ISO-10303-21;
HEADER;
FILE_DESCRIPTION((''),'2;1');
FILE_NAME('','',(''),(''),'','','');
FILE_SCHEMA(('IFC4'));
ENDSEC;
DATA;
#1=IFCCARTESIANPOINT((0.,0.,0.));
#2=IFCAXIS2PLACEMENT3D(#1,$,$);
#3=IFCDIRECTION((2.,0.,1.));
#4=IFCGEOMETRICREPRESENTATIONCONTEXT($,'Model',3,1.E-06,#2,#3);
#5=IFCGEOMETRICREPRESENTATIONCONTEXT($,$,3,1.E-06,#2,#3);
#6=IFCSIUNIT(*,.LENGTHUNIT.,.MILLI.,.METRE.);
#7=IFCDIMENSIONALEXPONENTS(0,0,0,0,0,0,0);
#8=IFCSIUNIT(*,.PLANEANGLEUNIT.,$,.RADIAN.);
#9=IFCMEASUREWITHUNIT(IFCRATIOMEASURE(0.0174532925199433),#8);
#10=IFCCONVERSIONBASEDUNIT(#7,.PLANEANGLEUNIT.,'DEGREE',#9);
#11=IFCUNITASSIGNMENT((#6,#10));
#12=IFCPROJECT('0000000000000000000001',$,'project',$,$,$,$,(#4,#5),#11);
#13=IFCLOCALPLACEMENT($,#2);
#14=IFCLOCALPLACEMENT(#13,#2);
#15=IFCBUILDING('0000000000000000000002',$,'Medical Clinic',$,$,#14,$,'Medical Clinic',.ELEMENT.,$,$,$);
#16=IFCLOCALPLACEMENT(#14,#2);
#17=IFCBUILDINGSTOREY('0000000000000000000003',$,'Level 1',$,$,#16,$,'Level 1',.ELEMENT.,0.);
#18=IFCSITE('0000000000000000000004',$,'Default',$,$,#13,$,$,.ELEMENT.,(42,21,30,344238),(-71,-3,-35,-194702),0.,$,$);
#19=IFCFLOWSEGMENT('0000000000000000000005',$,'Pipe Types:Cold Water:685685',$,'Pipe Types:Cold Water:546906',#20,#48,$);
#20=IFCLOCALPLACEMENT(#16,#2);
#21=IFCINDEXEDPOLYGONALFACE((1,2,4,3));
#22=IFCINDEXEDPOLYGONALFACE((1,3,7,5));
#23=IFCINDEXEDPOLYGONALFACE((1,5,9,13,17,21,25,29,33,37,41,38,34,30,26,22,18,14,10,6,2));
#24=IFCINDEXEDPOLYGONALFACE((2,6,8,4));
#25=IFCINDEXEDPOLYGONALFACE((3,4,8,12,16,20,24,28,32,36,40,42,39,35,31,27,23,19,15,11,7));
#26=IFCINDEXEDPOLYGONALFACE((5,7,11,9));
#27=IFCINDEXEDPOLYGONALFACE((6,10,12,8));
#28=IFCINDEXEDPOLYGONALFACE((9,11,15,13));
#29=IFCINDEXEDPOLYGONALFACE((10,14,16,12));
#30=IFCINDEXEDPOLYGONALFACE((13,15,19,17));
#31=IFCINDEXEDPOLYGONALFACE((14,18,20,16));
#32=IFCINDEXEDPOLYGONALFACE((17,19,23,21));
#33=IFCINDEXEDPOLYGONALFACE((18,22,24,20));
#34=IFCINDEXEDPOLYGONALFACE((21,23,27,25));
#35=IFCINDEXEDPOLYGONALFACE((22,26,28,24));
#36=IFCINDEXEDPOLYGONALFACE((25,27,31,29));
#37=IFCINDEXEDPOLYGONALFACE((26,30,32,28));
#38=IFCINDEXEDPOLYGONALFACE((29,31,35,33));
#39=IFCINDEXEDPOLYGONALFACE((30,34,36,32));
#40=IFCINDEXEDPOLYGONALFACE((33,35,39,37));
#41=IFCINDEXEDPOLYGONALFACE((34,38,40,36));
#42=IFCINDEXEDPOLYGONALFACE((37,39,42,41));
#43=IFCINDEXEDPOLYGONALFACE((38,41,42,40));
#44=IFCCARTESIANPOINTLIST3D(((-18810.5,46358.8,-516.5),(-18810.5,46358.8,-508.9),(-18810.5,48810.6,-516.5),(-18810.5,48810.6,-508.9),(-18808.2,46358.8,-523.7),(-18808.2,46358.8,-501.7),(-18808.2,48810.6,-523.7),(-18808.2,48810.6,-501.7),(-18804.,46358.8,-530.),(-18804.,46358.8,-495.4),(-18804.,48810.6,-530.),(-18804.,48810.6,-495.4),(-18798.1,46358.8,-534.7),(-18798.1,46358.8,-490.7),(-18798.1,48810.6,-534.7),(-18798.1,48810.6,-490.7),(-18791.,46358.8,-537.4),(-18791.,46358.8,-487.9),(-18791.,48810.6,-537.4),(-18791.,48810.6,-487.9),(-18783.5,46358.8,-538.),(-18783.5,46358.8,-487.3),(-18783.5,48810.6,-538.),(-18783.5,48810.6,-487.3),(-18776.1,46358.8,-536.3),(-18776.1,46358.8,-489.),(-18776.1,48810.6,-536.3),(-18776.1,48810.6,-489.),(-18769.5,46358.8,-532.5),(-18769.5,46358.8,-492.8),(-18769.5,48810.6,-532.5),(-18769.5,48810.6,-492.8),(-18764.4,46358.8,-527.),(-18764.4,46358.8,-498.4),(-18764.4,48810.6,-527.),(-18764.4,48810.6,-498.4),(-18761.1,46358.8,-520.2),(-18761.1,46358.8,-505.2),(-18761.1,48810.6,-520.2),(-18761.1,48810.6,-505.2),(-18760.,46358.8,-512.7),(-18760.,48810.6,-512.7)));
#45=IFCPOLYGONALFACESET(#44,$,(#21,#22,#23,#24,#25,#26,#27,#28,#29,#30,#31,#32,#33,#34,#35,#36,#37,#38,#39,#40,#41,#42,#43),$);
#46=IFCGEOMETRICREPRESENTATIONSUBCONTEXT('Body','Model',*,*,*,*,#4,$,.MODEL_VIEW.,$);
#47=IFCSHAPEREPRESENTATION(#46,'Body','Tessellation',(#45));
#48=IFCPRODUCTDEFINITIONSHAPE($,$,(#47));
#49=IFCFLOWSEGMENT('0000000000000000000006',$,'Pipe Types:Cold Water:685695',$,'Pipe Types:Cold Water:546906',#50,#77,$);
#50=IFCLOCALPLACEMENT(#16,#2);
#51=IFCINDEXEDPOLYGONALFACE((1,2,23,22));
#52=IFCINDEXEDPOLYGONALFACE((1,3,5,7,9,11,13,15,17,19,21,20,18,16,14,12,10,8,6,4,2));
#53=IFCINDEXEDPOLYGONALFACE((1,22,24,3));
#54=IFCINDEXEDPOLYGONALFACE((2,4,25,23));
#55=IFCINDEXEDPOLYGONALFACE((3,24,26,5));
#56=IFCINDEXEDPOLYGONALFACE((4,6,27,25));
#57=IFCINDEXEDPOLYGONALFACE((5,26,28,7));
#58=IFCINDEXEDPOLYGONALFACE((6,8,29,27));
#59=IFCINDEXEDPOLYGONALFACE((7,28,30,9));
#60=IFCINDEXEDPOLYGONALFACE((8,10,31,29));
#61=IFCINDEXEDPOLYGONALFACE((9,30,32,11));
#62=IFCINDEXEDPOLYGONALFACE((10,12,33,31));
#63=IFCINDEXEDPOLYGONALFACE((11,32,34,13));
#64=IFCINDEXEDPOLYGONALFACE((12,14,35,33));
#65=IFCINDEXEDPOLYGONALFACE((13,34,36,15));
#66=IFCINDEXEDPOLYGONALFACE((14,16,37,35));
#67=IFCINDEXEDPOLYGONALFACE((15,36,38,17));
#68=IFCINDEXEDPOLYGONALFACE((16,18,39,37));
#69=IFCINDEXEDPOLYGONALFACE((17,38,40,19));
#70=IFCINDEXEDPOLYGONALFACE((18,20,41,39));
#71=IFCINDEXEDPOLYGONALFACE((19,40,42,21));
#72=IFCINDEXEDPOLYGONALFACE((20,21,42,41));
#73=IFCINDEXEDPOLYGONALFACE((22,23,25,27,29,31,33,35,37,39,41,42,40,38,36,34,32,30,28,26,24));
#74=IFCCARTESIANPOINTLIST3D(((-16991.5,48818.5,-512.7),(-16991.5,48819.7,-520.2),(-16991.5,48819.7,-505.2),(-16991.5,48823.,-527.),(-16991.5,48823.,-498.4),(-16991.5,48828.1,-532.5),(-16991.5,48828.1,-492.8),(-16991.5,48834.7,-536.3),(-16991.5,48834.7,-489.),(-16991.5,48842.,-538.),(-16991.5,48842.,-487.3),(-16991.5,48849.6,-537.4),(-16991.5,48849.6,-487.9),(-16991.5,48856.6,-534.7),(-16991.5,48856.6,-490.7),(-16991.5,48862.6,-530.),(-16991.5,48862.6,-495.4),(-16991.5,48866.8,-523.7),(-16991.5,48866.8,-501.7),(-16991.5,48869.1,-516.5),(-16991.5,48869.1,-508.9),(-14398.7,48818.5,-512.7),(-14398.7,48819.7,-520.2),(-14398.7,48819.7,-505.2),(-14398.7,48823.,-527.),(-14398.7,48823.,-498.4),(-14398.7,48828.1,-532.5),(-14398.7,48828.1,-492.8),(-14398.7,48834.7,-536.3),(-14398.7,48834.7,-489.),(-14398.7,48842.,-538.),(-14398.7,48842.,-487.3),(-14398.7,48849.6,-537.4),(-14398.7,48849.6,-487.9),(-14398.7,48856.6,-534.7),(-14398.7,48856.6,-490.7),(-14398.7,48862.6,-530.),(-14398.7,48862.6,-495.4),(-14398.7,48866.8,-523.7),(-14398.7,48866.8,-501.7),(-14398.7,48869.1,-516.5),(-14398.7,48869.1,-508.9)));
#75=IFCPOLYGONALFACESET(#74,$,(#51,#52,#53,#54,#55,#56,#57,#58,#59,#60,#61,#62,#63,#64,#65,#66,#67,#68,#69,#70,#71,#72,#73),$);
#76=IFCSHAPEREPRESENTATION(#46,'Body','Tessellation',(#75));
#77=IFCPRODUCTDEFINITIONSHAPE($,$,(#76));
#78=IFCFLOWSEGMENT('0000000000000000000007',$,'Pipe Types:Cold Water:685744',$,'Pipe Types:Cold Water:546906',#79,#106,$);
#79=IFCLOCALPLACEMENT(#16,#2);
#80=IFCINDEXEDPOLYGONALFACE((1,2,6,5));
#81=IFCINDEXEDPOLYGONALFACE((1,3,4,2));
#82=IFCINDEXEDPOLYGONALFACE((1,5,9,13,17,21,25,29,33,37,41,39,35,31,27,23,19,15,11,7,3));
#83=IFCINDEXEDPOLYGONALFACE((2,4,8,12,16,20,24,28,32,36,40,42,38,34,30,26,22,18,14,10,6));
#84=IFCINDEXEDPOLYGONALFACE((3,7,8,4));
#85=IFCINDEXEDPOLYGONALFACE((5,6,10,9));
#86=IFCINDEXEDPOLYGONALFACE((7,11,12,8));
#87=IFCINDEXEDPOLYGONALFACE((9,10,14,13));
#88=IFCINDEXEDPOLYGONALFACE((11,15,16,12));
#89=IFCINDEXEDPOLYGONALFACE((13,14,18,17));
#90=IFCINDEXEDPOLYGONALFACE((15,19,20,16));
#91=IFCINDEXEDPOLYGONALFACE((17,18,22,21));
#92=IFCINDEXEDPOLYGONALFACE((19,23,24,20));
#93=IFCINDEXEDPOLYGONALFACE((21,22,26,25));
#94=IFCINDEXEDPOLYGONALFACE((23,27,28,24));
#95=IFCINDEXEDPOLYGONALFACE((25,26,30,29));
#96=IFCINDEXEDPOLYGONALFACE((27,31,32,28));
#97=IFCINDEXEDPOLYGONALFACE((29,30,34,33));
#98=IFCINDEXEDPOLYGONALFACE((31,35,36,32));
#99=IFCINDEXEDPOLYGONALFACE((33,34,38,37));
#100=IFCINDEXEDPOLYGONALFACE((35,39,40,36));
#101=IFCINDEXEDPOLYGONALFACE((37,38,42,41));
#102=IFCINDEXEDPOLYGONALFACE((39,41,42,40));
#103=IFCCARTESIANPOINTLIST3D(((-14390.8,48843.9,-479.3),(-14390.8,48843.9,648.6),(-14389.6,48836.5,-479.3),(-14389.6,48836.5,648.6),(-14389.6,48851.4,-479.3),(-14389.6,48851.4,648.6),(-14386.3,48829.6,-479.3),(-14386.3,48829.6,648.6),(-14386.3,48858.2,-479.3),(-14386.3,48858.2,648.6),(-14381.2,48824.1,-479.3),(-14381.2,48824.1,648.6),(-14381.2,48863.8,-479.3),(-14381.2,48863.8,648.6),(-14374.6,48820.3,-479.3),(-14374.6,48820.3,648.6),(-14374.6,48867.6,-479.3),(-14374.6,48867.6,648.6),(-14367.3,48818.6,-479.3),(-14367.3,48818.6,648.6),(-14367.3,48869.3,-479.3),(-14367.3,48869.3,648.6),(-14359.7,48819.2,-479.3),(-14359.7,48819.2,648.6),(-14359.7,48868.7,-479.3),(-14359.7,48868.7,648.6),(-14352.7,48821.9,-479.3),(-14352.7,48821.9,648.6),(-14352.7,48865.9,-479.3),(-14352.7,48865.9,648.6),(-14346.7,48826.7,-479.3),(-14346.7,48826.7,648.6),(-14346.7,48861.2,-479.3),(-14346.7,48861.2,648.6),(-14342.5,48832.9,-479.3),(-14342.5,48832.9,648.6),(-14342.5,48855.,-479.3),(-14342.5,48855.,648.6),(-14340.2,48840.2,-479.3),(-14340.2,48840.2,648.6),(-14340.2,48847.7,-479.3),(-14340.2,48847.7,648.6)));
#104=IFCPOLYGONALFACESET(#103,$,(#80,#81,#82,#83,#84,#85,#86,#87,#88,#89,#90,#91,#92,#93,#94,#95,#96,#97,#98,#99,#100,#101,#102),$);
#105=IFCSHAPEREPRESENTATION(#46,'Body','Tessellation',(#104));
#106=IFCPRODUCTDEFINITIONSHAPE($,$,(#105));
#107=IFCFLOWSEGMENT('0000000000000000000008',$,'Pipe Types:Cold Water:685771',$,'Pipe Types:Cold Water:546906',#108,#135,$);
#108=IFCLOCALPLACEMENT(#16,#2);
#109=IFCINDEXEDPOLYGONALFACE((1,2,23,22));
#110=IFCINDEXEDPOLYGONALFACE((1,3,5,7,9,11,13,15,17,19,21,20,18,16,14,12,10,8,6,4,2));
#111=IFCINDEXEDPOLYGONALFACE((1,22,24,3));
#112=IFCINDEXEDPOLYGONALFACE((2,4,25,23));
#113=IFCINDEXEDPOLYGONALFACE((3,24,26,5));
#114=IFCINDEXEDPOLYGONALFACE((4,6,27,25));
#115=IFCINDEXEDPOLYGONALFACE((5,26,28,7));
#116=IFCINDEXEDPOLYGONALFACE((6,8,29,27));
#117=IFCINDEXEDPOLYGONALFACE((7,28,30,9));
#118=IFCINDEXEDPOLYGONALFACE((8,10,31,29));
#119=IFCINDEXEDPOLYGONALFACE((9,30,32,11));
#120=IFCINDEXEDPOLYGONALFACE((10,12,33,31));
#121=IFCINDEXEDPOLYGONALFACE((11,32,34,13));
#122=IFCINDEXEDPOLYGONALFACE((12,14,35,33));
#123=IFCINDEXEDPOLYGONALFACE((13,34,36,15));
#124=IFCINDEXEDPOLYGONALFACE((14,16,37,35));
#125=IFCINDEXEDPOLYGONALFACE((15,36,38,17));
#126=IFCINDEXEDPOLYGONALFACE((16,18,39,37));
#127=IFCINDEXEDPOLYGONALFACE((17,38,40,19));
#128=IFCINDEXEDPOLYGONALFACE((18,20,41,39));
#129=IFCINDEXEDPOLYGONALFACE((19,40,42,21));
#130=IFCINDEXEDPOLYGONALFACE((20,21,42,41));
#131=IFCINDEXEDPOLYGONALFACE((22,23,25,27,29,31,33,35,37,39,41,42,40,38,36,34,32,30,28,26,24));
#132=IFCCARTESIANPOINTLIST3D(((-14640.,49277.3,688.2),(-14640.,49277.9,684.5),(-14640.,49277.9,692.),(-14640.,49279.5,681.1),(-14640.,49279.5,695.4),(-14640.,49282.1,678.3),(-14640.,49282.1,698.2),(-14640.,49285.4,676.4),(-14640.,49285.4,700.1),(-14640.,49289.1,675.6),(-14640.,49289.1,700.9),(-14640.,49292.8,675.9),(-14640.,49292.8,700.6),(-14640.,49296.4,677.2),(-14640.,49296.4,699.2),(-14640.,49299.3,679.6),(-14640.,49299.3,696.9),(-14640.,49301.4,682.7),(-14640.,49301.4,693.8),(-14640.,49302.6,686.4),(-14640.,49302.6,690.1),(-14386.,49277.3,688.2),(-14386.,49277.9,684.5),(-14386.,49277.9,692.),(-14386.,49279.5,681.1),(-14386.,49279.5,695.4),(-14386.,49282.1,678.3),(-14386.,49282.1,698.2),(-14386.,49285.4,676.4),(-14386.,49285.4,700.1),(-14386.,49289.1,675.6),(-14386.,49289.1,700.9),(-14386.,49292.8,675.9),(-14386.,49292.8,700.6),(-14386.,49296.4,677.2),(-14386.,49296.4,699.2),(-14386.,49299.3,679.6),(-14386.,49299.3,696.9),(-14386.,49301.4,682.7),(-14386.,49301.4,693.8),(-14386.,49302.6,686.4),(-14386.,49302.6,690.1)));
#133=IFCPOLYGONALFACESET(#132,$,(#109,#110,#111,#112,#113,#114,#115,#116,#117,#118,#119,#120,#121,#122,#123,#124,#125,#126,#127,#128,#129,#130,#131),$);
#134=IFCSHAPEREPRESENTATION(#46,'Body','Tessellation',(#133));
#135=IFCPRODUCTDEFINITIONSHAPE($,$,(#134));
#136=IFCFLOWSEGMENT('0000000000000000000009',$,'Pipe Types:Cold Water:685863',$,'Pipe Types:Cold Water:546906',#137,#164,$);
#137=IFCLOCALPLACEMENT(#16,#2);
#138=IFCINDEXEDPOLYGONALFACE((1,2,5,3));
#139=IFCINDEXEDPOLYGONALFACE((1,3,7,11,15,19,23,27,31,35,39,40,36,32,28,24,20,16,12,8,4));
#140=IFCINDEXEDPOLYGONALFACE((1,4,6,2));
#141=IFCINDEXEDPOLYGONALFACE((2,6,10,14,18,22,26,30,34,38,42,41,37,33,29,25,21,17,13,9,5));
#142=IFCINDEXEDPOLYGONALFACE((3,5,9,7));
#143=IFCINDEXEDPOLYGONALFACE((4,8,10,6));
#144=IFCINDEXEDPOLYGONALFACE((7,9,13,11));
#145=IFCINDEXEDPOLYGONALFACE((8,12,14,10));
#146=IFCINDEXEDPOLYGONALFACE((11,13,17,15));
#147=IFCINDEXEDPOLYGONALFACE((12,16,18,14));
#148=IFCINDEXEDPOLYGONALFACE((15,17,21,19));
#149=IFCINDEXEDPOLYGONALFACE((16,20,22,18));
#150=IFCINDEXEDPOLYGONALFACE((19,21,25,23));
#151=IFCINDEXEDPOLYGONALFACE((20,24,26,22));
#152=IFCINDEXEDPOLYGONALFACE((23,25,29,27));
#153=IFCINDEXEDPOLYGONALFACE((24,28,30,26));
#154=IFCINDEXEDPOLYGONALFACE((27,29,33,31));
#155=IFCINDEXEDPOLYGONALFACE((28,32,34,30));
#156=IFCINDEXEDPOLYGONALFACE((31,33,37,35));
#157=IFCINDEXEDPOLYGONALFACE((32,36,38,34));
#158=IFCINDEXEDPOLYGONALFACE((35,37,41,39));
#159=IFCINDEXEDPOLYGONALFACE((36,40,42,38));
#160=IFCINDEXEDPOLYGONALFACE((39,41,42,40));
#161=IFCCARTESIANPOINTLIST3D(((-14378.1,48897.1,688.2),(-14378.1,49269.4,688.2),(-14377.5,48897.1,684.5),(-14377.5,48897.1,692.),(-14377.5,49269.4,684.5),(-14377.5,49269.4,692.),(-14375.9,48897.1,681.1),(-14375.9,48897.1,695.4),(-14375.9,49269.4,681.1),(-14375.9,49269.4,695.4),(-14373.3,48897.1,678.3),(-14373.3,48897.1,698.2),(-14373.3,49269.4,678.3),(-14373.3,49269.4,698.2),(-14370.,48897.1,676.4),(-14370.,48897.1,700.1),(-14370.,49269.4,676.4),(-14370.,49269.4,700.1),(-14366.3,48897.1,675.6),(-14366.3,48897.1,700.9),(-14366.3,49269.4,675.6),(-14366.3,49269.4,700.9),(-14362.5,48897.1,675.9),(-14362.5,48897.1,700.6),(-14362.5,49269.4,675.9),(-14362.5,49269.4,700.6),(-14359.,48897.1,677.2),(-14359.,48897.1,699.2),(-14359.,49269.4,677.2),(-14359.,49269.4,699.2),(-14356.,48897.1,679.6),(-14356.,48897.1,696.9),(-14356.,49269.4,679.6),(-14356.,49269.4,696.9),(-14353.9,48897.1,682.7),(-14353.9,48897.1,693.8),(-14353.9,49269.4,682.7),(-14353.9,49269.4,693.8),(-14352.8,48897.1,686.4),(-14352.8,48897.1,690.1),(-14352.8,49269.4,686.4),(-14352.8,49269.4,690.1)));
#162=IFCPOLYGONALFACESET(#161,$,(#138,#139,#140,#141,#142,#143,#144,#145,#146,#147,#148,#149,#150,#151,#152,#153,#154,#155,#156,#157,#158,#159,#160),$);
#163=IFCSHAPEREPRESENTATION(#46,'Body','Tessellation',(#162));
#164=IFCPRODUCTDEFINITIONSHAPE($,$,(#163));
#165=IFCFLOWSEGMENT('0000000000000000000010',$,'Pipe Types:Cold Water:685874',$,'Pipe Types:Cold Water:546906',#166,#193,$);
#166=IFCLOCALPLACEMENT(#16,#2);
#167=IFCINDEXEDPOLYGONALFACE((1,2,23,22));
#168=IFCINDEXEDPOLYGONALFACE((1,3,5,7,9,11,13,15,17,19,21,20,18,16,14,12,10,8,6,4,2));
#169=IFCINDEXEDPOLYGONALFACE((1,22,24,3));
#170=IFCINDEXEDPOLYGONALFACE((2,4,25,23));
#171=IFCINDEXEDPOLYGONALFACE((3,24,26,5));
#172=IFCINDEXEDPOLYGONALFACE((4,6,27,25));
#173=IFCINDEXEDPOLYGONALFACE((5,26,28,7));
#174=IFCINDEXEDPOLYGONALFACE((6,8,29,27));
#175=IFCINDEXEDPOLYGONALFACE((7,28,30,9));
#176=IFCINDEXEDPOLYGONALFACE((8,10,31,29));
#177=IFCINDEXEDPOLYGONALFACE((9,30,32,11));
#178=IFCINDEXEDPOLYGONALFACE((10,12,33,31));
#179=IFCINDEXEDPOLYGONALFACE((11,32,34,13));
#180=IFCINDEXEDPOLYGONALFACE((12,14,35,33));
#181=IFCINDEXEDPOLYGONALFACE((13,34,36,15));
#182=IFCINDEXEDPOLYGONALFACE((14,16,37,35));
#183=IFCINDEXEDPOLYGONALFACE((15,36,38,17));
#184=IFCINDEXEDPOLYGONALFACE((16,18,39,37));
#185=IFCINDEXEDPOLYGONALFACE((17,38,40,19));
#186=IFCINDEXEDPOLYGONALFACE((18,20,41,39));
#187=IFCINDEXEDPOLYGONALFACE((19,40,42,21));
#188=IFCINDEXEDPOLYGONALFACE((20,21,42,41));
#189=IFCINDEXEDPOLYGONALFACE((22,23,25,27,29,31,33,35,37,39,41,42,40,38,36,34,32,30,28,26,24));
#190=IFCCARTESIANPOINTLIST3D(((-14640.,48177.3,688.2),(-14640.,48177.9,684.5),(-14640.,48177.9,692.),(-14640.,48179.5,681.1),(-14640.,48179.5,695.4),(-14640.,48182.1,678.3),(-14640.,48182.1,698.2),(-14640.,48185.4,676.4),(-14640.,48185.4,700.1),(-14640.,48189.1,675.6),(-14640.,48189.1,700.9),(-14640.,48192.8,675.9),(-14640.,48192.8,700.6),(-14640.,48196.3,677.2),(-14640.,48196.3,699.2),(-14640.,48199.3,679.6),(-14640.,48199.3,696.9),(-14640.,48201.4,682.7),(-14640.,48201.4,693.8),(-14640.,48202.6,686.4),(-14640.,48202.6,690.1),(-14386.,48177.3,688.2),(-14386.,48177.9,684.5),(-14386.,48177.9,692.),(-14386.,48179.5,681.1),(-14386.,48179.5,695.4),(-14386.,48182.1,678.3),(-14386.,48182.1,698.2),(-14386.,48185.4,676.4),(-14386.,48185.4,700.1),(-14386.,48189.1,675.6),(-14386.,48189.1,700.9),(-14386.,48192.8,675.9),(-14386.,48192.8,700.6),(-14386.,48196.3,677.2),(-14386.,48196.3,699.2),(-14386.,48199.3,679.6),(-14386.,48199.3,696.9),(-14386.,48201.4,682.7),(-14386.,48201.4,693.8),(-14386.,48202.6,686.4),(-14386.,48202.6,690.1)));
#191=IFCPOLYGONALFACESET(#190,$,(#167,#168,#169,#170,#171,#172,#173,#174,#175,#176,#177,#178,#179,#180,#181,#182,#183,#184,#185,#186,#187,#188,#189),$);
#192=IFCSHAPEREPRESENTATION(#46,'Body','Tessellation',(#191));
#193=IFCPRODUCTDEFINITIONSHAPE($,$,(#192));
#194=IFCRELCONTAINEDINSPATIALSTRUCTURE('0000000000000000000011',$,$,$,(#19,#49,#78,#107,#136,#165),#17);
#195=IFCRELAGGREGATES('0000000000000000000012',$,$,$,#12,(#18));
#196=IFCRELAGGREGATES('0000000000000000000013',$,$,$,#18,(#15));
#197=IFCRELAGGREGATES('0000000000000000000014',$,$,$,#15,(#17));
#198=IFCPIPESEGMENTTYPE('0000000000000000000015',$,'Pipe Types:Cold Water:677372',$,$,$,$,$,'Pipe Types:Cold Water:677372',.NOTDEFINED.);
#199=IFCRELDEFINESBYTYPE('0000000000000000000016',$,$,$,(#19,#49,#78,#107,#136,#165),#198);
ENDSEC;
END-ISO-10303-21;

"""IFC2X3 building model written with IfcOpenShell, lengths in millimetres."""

from ifc_helpers import new_model, entity, si_unit, converted_unit, direction, frame, frame_2d, origin, place, context, subcontext, project, spatial, circle, extrude, type_object, element, save


model = new_model("IFC2X3")

# Units and contexts
model_context = context("Model", 3, precision=1e-06, world=origin(), true_north=direction((2.0, 0.0, 1.0)))
context_of_model = context(None, 3, precision=1e-06, world=origin(), true_north=direction((2.0, 0.0, 1.0)))
body_context = subcontext(model_context, "Body", "Model", "MODEL_VIEW")
ifc_project = project(units=[si_unit("LENGTHUNIT", "METRE", prefix="MILLI"), converted_unit("PLANEANGLEUNIT", "DEGREE", entity("IfcRatioMeasure", 0.0174532925199433), si_unit("PLANEANGLEUNIT", "RADIAN"), dimensions=[0, 0, 0, 0, 0, 0, 0])], contexts=[model_context, context_of_model])

# Site, building, storey
site_placement = place(None, origin())
site = spatial("IfcSite", under=ifc_project, at=site_placement, Name="Default", CompositionType="ELEMENT", RefLatitude=(42, 21, 30, 344238), RefLongitude=(-71, -3, -35, -194702), RefElevation=0.0)
building_placement = place(site_placement, origin())
building = spatial("IfcBuilding", under=site, at=building_placement, Name="Medical Clinic", LongName="Medical Clinic", CompositionType="ELEMENT")
storey_placement = place(building_placement, origin())
storey = spatial("IfcBuildingStorey", under=building, at=storey_placement, Name="Level 1", LongName="Level 1", CompositionType="ELEMENT", Elevation=0.0)

# Flow segments
pipe_segment_type = type_object("IfcPipeSegmentType", Name="Pipe Types:Cold Water:677372", ElementType="Pipe Types:Cold Water:677372", PredefinedType="NOTDEFINED")
flow_segment_1_placement = place(storey_placement, origin())
element("IfcFlowSegment", 1, at=flow_segment_1_placement, inside=storey, type_object=pipe_segment_type, Name="Pipe Types:Cold Water:685685", ObjectType="Pipe Types:Cold Water:546906", context=body_context, shape_type="SweptSolid", body=[
    extrude(circle(Radius=25.4, at=frame_2d((0.0, 0.0), x_axis=(1.0, 0.0))), frame((-18785.4, 46358.8, -512.7), z_axis=(0.0, 1.0, 0.0), x_axis=(1.0, 0.0, 0.0)), (0.0, 0.0, 1.0), 2451.8),
])
flow_segment_2_placement = place(storey_placement, origin())
element("IfcFlowSegment", 2, at=flow_segment_2_placement, inside=storey, type_object=pipe_segment_type, Name="Pipe Types:Cold Water:685695", ObjectType="Pipe Types:Cold Water:546906", context=body_context, shape_type="SweptSolid", body=[
    extrude(circle(Radius=25.4, at=frame_2d((0.0, 0.0), x_axis=(1.0, 0.0))), frame((-16991.5, 48843.9, -512.7), z_axis=(1.0, 0.0, 0.0), x_axis=(0.0, -1.0, 0.0)), (0.0, 0.0, 1.0), 2592.8),
])
flow_segment_3_placement = place(storey_placement, origin())
element("IfcFlowSegment", 3, at=flow_segment_3_placement, inside=storey, type_object=pipe_segment_type, Name="Pipe Types:Cold Water:685744", ObjectType="Pipe Types:Cold Water:546906", context=body_context, shape_type="SweptSolid", body=[
    extrude(circle(Radius=25.4, at=frame_2d((0.0, 0.0), x_axis=(1.0, 0.0))), frame((-14365.4, 48843.9, -479.3), z_axis=(0.0, 0.0, 1.0), x_axis=(-1.0, 0.0, 0.0)), (0.0, 0.0, 1.0), 1127.9),
])
flow_segment_4_placement = place(storey_placement, origin())
element("IfcFlowSegment", 4, at=flow_segment_4_placement, inside=storey, type_object=pipe_segment_type, Name="Pipe Types:Cold Water:685771", ObjectType="Pipe Types:Cold Water:546906", context=body_context, shape_type="SweptSolid", body=[
    extrude(circle(Radius=12.7, at=frame_2d((0.0, 0.0), x_axis=(1.0, 0.0))), frame((-14640.0, 49290.0, 688.2), z_axis=(1.0, 0.0, 0.0), x_axis=(0.0, -1.0, 0.0)), (0.0, 0.0, 1.0), 254.0),
])
flow_segment_5_placement = place(storey_placement, origin())
element("IfcFlowSegment", 5, at=flow_segment_5_placement, inside=storey, type_object=pipe_segment_type, Name="Pipe Types:Cold Water:685863", ObjectType="Pipe Types:Cold Water:546906", context=body_context, shape_type="SweptSolid", body=[
    extrude(circle(Radius=12.7, at=frame_2d((0.0, 0.0), x_axis=(1.0, 0.0))), frame((-14365.4, 48897.1, 688.2), z_axis=(0.0, 1.0, 0.0), x_axis=(-1.0, 0.0, 0.0)), (0.0, 0.0, 1.0), 372.2),
])
flow_segment_6_placement = place(storey_placement, origin())
element("IfcFlowSegment", 6, at=flow_segment_6_placement, inside=storey, type_object=pipe_segment_type, Name="Pipe Types:Cold Water:685874", ObjectType="Pipe Types:Cold Water:546906", context=body_context, shape_type="SweptSolid", body=[
    extrude(circle(Radius=12.7, at=frame_2d((0.0, 0.0), x_axis=(1.0, 0.0))), frame((-14640.0, 48190.0, 688.2), z_axis=(1.0, 0.0, 0.0), x_axis=(0.0, -1.0, 0.0)), (0.0, 0.0, 1.0), 254.0),
])

save(model, "model.ifc")
